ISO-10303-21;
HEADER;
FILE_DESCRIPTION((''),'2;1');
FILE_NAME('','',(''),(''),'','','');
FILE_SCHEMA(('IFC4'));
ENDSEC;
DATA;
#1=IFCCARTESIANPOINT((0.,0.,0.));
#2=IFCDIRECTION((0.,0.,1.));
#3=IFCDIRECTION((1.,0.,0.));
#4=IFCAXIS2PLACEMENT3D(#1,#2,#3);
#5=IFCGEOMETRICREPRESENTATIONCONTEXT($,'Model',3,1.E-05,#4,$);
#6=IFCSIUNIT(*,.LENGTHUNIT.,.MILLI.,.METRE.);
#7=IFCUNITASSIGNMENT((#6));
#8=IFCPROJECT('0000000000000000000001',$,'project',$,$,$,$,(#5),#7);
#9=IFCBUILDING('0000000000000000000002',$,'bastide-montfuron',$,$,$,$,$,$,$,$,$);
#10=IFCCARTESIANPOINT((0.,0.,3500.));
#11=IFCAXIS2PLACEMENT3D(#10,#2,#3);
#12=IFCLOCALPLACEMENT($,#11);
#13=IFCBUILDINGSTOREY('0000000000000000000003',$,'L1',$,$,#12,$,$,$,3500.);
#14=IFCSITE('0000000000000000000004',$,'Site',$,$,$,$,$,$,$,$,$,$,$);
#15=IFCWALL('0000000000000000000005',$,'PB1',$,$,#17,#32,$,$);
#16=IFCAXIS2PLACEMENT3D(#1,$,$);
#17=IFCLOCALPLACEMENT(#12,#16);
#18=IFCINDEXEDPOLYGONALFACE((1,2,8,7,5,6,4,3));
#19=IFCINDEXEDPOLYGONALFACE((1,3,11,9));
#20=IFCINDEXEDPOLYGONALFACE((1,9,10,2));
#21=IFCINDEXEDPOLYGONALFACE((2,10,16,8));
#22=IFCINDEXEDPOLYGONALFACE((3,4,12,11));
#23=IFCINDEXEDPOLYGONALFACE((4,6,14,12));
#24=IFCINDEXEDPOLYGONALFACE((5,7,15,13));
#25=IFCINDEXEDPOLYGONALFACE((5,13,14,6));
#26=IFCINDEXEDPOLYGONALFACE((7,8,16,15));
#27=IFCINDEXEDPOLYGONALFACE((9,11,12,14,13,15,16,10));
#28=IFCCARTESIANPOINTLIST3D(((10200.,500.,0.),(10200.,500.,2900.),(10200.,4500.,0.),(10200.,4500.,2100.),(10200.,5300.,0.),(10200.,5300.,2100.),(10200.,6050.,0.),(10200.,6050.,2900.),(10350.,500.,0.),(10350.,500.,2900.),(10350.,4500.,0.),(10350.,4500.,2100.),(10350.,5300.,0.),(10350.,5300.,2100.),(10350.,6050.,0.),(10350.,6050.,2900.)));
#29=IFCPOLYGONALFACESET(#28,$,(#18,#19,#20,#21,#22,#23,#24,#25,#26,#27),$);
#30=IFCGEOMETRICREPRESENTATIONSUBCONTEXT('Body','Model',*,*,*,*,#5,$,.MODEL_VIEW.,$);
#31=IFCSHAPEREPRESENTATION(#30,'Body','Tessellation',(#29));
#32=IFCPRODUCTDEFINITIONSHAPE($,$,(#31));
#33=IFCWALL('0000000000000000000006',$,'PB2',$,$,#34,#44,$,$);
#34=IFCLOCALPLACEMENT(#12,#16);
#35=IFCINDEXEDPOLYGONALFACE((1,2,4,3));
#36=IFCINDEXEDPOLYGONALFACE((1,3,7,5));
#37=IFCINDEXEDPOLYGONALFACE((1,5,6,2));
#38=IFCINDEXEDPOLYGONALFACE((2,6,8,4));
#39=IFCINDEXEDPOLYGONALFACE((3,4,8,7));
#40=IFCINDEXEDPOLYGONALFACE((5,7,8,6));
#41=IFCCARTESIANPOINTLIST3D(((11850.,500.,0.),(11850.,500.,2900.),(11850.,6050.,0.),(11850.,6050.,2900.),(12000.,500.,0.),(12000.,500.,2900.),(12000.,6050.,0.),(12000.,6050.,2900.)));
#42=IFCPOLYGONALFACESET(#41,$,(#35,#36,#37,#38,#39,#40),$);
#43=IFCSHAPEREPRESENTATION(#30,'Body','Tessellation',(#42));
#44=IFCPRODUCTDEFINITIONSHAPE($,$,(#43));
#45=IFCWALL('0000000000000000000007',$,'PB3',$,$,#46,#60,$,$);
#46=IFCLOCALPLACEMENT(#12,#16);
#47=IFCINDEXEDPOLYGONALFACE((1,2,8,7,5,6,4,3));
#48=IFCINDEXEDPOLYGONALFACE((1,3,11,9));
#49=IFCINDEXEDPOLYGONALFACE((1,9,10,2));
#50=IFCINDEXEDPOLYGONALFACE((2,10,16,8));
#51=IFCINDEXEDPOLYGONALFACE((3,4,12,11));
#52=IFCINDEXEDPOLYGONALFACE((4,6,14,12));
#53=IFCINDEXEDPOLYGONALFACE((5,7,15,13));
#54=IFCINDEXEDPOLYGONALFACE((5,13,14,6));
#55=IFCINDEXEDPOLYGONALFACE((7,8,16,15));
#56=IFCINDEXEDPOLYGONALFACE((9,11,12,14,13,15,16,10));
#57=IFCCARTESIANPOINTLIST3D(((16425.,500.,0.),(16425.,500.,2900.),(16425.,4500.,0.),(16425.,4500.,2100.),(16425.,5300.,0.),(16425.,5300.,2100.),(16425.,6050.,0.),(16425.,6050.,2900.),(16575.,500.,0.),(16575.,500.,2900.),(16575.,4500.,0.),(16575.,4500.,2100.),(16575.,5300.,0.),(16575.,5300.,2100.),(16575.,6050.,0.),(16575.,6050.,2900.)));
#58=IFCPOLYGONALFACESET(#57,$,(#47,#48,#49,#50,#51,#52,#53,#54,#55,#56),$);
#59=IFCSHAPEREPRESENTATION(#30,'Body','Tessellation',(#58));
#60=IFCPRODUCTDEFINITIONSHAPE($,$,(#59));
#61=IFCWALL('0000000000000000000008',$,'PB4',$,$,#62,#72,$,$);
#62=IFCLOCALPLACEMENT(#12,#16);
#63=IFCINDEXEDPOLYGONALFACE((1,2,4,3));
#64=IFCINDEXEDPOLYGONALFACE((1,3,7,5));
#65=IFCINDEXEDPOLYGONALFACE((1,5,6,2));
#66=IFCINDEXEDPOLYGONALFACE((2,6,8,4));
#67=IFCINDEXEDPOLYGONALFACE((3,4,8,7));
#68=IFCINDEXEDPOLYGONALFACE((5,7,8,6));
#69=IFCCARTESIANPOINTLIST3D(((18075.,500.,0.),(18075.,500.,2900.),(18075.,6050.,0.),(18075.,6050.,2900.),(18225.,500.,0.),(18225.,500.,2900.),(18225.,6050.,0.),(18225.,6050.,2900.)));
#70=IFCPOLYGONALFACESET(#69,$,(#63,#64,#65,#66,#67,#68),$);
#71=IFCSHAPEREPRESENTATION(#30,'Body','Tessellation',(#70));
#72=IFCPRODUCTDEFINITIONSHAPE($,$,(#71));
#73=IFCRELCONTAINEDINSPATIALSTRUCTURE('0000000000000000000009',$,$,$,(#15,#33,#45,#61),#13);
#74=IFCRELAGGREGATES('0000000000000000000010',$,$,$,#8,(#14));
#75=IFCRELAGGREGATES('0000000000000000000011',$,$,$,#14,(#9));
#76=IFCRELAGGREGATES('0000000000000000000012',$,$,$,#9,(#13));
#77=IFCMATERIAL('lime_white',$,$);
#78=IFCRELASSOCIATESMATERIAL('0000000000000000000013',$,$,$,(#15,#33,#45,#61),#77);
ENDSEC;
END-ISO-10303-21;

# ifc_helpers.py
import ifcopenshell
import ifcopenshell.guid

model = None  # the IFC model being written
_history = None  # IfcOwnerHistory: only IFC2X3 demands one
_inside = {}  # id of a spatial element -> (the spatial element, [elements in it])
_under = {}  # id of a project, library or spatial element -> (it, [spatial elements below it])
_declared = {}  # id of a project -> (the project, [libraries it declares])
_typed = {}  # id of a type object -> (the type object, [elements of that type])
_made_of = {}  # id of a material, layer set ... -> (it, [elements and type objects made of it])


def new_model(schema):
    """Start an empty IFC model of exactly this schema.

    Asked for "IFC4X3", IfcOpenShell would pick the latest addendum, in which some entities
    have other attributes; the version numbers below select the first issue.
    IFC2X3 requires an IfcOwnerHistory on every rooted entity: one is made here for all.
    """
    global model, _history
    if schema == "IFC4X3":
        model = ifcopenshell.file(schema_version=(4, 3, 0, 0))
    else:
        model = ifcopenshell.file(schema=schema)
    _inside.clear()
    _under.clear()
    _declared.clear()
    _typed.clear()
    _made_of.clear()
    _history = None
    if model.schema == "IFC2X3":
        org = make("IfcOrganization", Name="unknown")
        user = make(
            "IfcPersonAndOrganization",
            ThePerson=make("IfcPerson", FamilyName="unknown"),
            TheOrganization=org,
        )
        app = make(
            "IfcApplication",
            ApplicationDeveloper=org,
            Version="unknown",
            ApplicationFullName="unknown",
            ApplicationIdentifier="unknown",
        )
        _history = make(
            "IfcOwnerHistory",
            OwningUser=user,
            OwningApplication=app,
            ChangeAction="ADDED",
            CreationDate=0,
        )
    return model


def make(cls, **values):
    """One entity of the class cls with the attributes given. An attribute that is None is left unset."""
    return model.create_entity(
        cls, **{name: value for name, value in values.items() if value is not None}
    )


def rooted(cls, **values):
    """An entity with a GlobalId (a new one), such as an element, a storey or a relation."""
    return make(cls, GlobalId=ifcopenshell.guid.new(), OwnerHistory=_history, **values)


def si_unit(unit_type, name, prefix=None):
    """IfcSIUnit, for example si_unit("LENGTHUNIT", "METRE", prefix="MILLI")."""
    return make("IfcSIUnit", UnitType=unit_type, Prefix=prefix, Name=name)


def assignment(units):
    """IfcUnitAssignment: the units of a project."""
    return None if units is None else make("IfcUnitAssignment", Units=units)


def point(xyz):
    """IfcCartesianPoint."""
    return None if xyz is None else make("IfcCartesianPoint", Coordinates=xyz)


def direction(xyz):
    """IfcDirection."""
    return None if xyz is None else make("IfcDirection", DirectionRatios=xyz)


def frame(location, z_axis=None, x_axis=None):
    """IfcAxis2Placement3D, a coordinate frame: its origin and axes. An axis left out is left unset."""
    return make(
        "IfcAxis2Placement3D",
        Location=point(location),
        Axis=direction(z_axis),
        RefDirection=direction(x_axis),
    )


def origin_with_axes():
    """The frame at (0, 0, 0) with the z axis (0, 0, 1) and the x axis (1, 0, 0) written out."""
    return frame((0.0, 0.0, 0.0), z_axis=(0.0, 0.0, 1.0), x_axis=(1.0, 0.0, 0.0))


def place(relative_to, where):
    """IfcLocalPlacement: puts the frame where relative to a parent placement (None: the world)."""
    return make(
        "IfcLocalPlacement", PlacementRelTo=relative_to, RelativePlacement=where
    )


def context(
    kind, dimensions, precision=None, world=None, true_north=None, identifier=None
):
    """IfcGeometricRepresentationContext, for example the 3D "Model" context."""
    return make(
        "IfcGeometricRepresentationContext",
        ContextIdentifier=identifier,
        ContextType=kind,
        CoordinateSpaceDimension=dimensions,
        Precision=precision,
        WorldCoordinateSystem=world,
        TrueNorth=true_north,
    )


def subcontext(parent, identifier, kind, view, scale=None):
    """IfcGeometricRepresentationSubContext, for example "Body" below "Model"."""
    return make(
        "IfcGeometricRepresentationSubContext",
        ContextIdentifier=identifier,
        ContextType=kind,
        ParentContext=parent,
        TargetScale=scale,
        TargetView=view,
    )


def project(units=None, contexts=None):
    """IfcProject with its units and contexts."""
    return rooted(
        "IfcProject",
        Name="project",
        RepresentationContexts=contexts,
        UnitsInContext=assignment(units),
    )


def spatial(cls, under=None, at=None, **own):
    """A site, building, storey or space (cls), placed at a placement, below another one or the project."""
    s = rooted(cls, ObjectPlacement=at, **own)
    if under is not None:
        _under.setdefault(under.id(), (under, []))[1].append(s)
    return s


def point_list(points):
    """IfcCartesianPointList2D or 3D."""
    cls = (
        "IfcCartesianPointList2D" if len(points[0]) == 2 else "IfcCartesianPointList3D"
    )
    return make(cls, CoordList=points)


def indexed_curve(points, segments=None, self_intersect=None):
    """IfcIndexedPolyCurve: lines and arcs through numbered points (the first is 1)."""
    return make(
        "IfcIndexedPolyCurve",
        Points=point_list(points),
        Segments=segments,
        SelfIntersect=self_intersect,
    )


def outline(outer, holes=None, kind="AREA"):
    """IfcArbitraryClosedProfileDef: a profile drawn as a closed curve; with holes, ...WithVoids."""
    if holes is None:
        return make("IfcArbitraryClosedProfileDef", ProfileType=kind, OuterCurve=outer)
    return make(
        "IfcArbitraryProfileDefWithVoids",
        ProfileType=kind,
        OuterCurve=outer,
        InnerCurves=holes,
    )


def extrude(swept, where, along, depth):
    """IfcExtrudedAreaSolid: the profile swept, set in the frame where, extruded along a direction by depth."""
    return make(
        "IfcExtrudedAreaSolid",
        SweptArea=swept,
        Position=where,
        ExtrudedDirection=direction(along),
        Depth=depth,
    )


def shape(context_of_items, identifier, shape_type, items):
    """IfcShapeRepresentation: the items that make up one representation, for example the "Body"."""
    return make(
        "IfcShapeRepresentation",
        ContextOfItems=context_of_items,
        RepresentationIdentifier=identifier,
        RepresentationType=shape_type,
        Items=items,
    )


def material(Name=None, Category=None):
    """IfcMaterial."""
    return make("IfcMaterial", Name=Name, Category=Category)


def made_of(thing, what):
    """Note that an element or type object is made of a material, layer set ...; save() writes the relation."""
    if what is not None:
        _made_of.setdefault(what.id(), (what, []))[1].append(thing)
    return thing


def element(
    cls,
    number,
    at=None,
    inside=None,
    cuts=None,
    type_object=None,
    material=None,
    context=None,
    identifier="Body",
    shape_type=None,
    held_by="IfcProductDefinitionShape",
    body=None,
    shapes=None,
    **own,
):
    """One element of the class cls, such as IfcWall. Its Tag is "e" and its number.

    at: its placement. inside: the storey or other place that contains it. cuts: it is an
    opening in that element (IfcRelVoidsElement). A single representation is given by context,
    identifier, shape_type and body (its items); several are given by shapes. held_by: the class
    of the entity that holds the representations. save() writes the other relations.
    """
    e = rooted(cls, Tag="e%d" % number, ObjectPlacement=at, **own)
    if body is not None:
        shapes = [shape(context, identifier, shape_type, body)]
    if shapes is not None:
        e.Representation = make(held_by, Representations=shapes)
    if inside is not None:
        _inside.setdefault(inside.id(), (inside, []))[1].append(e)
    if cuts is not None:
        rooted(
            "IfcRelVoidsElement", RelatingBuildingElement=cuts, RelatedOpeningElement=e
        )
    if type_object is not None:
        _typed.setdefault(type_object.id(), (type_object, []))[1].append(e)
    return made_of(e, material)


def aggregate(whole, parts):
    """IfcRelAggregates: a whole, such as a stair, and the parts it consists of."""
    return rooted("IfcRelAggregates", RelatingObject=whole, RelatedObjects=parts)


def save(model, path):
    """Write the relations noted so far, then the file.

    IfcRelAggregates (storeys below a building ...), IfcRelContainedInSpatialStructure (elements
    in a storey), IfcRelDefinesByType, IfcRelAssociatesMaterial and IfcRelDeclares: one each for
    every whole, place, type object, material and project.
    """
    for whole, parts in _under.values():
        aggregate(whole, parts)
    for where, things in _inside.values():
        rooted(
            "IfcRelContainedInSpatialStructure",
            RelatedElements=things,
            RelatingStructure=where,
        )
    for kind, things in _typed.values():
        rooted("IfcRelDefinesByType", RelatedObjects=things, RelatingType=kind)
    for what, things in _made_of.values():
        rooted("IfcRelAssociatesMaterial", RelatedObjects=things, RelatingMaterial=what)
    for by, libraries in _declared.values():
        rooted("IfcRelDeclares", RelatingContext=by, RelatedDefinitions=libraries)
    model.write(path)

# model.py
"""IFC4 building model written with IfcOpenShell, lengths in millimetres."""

from ifc_helpers import new_model, si_unit, frame, origin_with_axes, place, context, subcontext, project, spatial, indexed_curve, outline, extrude, material, element, save


model = new_model("IFC4")

# Units and contexts
model_context = context("Model", 3, precision=1e-05, world=origin_with_axes())
body_context = subcontext(model_context, "Body", "Model", "MODEL_VIEW")
ifc_project = project(units=[si_unit("LENGTHUNIT", "METRE", prefix="MILLI")], contexts=[model_context])

# Site, building, storey
site = spatial("IfcSite", under=ifc_project, Name="Site")
building = spatial("IfcBuilding", under=site, Name="bastide-montfuron")
storey_placement = place(None, frame((0.0, 0.0, 3500.0), z_axis=(0.0, 0.0, 1.0), x_axis=(1.0, 0.0, 0.0)))
storey = spatial("IfcBuildingStorey", under=building, at=storey_placement, Name="L1", Elevation=3500.0)

# Shared definitions
ifc_material = material(Name="lime_white")

# Wall, opening
wall_1_placement = place(storey_placement, frame((10350.0, 500.0, 0.0), z_axis=(0.0, 0.0, 1.0), x_axis=(0.0, 1.0, 0.0)))
wall_1 = element("IfcWall", 1, at=wall_1_placement, inside=storey, material=ifc_material, Name="PB1", context=body_context, shape_type="SweptSolid", body=[
    extrude(outline(indexed_curve([(0.0, 0.0), (0.0, 150.0), (5550.0, 150.0), (5550.0, 0.0), (0.0, 0.0)], self_intersect=False)), origin_with_axes(), (0.0, 0.0, 1.0), 2900.0),
])
opening_1_placement = place(wall_1_placement, frame((4000.0, -100.0, 0.0), z_axis=(0.0, 0.0, 1.0), x_axis=(1.0, 0.0, 0.0)))
element("IfcOpeningElement", 2, at=opening_1_placement, cuts=wall_1, context=body_context, shape_type="SweptSolid", body=[
    extrude(outline(indexed_curve([(0.0, 0.0), (0.0, 350.0), (800.0, 350.0), (800.0, 0.0), (0.0, 0.0)], self_intersect=False)), origin_with_axes(), (0.0, 0.0, 1.0), 2100.0),
])

# Wall
wall_2_placement = place(storey_placement, frame((12000.0, 500.0, 0.0), z_axis=(0.0, 0.0, 1.0), x_axis=(0.0, 1.0, 0.0)))
element("IfcWall", 3, at=wall_2_placement, inside=storey, material=ifc_material, Name="PB2", context=body_context, shape_type="SweptSolid", body=[
    extrude(outline(indexed_curve([(0.0, 0.0), (0.0, 150.0), (5550.0, 150.0), (5550.0, 0.0), (0.0, 0.0)], self_intersect=False)), origin_with_axes(), (0.0, 0.0, 1.0), 2900.0),
])

# Wall, opening
wall_3_placement = place(storey_placement, frame((16575.0, 500.0, 0.0), z_axis=(0.0, 0.0, 1.0), x_axis=(0.0, 1.0, 0.0)))
wall_3 = element("IfcWall", 4, at=wall_3_placement, inside=storey, material=ifc_material, Name="PB3", context=body_context, shape_type="SweptSolid", body=[
    extrude(outline(indexed_curve([(0.0, 0.0), (0.0, 150.0), (5550.0, 150.0), (5550.0, 0.0), (0.0, 0.0)], self_intersect=False)), origin_with_axes(), (0.0, 0.0, 1.0), 2900.0),
])
opening_2_placement = place(wall_3_placement, frame((4000.0, -100.0, 0.0), z_axis=(0.0, 0.0, 1.0), x_axis=(1.0, 0.0, 0.0)))
element("IfcOpeningElement", 5, at=opening_2_placement, cuts=wall_3, context=body_context, shape_type="SweptSolid", body=[
    extrude(outline(indexed_curve([(0.0, 0.0), (0.0, 350.0), (800.0, 350.0), (800.0, 0.0), (0.0, 0.0)], self_intersect=False)), origin_with_axes(), (0.0, 0.0, 1.0), 2100.0),
])

# Wall
wall_4_placement = place(storey_placement, frame((18225.0, 500.0, 0.0), z_axis=(0.0, 0.0, 1.0), x_axis=(0.0, 1.0, 0.0)))
element("IfcWall", 6, at=wall_4_placement, inside=storey, material=ifc_material, Name="PB4", context=body_context, shape_type="SweptSolid", body=[
    extrude(outline(indexed_curve([(0.0, 0.0), (0.0, 150.0), (5550.0, 150.0), (5550.0, 0.0), (0.0, 0.0)], self_intersect=False)), origin_with_axes(), (0.0, 0.0, 1.0), 2900.0),
])

save(model, "model.ifc")
